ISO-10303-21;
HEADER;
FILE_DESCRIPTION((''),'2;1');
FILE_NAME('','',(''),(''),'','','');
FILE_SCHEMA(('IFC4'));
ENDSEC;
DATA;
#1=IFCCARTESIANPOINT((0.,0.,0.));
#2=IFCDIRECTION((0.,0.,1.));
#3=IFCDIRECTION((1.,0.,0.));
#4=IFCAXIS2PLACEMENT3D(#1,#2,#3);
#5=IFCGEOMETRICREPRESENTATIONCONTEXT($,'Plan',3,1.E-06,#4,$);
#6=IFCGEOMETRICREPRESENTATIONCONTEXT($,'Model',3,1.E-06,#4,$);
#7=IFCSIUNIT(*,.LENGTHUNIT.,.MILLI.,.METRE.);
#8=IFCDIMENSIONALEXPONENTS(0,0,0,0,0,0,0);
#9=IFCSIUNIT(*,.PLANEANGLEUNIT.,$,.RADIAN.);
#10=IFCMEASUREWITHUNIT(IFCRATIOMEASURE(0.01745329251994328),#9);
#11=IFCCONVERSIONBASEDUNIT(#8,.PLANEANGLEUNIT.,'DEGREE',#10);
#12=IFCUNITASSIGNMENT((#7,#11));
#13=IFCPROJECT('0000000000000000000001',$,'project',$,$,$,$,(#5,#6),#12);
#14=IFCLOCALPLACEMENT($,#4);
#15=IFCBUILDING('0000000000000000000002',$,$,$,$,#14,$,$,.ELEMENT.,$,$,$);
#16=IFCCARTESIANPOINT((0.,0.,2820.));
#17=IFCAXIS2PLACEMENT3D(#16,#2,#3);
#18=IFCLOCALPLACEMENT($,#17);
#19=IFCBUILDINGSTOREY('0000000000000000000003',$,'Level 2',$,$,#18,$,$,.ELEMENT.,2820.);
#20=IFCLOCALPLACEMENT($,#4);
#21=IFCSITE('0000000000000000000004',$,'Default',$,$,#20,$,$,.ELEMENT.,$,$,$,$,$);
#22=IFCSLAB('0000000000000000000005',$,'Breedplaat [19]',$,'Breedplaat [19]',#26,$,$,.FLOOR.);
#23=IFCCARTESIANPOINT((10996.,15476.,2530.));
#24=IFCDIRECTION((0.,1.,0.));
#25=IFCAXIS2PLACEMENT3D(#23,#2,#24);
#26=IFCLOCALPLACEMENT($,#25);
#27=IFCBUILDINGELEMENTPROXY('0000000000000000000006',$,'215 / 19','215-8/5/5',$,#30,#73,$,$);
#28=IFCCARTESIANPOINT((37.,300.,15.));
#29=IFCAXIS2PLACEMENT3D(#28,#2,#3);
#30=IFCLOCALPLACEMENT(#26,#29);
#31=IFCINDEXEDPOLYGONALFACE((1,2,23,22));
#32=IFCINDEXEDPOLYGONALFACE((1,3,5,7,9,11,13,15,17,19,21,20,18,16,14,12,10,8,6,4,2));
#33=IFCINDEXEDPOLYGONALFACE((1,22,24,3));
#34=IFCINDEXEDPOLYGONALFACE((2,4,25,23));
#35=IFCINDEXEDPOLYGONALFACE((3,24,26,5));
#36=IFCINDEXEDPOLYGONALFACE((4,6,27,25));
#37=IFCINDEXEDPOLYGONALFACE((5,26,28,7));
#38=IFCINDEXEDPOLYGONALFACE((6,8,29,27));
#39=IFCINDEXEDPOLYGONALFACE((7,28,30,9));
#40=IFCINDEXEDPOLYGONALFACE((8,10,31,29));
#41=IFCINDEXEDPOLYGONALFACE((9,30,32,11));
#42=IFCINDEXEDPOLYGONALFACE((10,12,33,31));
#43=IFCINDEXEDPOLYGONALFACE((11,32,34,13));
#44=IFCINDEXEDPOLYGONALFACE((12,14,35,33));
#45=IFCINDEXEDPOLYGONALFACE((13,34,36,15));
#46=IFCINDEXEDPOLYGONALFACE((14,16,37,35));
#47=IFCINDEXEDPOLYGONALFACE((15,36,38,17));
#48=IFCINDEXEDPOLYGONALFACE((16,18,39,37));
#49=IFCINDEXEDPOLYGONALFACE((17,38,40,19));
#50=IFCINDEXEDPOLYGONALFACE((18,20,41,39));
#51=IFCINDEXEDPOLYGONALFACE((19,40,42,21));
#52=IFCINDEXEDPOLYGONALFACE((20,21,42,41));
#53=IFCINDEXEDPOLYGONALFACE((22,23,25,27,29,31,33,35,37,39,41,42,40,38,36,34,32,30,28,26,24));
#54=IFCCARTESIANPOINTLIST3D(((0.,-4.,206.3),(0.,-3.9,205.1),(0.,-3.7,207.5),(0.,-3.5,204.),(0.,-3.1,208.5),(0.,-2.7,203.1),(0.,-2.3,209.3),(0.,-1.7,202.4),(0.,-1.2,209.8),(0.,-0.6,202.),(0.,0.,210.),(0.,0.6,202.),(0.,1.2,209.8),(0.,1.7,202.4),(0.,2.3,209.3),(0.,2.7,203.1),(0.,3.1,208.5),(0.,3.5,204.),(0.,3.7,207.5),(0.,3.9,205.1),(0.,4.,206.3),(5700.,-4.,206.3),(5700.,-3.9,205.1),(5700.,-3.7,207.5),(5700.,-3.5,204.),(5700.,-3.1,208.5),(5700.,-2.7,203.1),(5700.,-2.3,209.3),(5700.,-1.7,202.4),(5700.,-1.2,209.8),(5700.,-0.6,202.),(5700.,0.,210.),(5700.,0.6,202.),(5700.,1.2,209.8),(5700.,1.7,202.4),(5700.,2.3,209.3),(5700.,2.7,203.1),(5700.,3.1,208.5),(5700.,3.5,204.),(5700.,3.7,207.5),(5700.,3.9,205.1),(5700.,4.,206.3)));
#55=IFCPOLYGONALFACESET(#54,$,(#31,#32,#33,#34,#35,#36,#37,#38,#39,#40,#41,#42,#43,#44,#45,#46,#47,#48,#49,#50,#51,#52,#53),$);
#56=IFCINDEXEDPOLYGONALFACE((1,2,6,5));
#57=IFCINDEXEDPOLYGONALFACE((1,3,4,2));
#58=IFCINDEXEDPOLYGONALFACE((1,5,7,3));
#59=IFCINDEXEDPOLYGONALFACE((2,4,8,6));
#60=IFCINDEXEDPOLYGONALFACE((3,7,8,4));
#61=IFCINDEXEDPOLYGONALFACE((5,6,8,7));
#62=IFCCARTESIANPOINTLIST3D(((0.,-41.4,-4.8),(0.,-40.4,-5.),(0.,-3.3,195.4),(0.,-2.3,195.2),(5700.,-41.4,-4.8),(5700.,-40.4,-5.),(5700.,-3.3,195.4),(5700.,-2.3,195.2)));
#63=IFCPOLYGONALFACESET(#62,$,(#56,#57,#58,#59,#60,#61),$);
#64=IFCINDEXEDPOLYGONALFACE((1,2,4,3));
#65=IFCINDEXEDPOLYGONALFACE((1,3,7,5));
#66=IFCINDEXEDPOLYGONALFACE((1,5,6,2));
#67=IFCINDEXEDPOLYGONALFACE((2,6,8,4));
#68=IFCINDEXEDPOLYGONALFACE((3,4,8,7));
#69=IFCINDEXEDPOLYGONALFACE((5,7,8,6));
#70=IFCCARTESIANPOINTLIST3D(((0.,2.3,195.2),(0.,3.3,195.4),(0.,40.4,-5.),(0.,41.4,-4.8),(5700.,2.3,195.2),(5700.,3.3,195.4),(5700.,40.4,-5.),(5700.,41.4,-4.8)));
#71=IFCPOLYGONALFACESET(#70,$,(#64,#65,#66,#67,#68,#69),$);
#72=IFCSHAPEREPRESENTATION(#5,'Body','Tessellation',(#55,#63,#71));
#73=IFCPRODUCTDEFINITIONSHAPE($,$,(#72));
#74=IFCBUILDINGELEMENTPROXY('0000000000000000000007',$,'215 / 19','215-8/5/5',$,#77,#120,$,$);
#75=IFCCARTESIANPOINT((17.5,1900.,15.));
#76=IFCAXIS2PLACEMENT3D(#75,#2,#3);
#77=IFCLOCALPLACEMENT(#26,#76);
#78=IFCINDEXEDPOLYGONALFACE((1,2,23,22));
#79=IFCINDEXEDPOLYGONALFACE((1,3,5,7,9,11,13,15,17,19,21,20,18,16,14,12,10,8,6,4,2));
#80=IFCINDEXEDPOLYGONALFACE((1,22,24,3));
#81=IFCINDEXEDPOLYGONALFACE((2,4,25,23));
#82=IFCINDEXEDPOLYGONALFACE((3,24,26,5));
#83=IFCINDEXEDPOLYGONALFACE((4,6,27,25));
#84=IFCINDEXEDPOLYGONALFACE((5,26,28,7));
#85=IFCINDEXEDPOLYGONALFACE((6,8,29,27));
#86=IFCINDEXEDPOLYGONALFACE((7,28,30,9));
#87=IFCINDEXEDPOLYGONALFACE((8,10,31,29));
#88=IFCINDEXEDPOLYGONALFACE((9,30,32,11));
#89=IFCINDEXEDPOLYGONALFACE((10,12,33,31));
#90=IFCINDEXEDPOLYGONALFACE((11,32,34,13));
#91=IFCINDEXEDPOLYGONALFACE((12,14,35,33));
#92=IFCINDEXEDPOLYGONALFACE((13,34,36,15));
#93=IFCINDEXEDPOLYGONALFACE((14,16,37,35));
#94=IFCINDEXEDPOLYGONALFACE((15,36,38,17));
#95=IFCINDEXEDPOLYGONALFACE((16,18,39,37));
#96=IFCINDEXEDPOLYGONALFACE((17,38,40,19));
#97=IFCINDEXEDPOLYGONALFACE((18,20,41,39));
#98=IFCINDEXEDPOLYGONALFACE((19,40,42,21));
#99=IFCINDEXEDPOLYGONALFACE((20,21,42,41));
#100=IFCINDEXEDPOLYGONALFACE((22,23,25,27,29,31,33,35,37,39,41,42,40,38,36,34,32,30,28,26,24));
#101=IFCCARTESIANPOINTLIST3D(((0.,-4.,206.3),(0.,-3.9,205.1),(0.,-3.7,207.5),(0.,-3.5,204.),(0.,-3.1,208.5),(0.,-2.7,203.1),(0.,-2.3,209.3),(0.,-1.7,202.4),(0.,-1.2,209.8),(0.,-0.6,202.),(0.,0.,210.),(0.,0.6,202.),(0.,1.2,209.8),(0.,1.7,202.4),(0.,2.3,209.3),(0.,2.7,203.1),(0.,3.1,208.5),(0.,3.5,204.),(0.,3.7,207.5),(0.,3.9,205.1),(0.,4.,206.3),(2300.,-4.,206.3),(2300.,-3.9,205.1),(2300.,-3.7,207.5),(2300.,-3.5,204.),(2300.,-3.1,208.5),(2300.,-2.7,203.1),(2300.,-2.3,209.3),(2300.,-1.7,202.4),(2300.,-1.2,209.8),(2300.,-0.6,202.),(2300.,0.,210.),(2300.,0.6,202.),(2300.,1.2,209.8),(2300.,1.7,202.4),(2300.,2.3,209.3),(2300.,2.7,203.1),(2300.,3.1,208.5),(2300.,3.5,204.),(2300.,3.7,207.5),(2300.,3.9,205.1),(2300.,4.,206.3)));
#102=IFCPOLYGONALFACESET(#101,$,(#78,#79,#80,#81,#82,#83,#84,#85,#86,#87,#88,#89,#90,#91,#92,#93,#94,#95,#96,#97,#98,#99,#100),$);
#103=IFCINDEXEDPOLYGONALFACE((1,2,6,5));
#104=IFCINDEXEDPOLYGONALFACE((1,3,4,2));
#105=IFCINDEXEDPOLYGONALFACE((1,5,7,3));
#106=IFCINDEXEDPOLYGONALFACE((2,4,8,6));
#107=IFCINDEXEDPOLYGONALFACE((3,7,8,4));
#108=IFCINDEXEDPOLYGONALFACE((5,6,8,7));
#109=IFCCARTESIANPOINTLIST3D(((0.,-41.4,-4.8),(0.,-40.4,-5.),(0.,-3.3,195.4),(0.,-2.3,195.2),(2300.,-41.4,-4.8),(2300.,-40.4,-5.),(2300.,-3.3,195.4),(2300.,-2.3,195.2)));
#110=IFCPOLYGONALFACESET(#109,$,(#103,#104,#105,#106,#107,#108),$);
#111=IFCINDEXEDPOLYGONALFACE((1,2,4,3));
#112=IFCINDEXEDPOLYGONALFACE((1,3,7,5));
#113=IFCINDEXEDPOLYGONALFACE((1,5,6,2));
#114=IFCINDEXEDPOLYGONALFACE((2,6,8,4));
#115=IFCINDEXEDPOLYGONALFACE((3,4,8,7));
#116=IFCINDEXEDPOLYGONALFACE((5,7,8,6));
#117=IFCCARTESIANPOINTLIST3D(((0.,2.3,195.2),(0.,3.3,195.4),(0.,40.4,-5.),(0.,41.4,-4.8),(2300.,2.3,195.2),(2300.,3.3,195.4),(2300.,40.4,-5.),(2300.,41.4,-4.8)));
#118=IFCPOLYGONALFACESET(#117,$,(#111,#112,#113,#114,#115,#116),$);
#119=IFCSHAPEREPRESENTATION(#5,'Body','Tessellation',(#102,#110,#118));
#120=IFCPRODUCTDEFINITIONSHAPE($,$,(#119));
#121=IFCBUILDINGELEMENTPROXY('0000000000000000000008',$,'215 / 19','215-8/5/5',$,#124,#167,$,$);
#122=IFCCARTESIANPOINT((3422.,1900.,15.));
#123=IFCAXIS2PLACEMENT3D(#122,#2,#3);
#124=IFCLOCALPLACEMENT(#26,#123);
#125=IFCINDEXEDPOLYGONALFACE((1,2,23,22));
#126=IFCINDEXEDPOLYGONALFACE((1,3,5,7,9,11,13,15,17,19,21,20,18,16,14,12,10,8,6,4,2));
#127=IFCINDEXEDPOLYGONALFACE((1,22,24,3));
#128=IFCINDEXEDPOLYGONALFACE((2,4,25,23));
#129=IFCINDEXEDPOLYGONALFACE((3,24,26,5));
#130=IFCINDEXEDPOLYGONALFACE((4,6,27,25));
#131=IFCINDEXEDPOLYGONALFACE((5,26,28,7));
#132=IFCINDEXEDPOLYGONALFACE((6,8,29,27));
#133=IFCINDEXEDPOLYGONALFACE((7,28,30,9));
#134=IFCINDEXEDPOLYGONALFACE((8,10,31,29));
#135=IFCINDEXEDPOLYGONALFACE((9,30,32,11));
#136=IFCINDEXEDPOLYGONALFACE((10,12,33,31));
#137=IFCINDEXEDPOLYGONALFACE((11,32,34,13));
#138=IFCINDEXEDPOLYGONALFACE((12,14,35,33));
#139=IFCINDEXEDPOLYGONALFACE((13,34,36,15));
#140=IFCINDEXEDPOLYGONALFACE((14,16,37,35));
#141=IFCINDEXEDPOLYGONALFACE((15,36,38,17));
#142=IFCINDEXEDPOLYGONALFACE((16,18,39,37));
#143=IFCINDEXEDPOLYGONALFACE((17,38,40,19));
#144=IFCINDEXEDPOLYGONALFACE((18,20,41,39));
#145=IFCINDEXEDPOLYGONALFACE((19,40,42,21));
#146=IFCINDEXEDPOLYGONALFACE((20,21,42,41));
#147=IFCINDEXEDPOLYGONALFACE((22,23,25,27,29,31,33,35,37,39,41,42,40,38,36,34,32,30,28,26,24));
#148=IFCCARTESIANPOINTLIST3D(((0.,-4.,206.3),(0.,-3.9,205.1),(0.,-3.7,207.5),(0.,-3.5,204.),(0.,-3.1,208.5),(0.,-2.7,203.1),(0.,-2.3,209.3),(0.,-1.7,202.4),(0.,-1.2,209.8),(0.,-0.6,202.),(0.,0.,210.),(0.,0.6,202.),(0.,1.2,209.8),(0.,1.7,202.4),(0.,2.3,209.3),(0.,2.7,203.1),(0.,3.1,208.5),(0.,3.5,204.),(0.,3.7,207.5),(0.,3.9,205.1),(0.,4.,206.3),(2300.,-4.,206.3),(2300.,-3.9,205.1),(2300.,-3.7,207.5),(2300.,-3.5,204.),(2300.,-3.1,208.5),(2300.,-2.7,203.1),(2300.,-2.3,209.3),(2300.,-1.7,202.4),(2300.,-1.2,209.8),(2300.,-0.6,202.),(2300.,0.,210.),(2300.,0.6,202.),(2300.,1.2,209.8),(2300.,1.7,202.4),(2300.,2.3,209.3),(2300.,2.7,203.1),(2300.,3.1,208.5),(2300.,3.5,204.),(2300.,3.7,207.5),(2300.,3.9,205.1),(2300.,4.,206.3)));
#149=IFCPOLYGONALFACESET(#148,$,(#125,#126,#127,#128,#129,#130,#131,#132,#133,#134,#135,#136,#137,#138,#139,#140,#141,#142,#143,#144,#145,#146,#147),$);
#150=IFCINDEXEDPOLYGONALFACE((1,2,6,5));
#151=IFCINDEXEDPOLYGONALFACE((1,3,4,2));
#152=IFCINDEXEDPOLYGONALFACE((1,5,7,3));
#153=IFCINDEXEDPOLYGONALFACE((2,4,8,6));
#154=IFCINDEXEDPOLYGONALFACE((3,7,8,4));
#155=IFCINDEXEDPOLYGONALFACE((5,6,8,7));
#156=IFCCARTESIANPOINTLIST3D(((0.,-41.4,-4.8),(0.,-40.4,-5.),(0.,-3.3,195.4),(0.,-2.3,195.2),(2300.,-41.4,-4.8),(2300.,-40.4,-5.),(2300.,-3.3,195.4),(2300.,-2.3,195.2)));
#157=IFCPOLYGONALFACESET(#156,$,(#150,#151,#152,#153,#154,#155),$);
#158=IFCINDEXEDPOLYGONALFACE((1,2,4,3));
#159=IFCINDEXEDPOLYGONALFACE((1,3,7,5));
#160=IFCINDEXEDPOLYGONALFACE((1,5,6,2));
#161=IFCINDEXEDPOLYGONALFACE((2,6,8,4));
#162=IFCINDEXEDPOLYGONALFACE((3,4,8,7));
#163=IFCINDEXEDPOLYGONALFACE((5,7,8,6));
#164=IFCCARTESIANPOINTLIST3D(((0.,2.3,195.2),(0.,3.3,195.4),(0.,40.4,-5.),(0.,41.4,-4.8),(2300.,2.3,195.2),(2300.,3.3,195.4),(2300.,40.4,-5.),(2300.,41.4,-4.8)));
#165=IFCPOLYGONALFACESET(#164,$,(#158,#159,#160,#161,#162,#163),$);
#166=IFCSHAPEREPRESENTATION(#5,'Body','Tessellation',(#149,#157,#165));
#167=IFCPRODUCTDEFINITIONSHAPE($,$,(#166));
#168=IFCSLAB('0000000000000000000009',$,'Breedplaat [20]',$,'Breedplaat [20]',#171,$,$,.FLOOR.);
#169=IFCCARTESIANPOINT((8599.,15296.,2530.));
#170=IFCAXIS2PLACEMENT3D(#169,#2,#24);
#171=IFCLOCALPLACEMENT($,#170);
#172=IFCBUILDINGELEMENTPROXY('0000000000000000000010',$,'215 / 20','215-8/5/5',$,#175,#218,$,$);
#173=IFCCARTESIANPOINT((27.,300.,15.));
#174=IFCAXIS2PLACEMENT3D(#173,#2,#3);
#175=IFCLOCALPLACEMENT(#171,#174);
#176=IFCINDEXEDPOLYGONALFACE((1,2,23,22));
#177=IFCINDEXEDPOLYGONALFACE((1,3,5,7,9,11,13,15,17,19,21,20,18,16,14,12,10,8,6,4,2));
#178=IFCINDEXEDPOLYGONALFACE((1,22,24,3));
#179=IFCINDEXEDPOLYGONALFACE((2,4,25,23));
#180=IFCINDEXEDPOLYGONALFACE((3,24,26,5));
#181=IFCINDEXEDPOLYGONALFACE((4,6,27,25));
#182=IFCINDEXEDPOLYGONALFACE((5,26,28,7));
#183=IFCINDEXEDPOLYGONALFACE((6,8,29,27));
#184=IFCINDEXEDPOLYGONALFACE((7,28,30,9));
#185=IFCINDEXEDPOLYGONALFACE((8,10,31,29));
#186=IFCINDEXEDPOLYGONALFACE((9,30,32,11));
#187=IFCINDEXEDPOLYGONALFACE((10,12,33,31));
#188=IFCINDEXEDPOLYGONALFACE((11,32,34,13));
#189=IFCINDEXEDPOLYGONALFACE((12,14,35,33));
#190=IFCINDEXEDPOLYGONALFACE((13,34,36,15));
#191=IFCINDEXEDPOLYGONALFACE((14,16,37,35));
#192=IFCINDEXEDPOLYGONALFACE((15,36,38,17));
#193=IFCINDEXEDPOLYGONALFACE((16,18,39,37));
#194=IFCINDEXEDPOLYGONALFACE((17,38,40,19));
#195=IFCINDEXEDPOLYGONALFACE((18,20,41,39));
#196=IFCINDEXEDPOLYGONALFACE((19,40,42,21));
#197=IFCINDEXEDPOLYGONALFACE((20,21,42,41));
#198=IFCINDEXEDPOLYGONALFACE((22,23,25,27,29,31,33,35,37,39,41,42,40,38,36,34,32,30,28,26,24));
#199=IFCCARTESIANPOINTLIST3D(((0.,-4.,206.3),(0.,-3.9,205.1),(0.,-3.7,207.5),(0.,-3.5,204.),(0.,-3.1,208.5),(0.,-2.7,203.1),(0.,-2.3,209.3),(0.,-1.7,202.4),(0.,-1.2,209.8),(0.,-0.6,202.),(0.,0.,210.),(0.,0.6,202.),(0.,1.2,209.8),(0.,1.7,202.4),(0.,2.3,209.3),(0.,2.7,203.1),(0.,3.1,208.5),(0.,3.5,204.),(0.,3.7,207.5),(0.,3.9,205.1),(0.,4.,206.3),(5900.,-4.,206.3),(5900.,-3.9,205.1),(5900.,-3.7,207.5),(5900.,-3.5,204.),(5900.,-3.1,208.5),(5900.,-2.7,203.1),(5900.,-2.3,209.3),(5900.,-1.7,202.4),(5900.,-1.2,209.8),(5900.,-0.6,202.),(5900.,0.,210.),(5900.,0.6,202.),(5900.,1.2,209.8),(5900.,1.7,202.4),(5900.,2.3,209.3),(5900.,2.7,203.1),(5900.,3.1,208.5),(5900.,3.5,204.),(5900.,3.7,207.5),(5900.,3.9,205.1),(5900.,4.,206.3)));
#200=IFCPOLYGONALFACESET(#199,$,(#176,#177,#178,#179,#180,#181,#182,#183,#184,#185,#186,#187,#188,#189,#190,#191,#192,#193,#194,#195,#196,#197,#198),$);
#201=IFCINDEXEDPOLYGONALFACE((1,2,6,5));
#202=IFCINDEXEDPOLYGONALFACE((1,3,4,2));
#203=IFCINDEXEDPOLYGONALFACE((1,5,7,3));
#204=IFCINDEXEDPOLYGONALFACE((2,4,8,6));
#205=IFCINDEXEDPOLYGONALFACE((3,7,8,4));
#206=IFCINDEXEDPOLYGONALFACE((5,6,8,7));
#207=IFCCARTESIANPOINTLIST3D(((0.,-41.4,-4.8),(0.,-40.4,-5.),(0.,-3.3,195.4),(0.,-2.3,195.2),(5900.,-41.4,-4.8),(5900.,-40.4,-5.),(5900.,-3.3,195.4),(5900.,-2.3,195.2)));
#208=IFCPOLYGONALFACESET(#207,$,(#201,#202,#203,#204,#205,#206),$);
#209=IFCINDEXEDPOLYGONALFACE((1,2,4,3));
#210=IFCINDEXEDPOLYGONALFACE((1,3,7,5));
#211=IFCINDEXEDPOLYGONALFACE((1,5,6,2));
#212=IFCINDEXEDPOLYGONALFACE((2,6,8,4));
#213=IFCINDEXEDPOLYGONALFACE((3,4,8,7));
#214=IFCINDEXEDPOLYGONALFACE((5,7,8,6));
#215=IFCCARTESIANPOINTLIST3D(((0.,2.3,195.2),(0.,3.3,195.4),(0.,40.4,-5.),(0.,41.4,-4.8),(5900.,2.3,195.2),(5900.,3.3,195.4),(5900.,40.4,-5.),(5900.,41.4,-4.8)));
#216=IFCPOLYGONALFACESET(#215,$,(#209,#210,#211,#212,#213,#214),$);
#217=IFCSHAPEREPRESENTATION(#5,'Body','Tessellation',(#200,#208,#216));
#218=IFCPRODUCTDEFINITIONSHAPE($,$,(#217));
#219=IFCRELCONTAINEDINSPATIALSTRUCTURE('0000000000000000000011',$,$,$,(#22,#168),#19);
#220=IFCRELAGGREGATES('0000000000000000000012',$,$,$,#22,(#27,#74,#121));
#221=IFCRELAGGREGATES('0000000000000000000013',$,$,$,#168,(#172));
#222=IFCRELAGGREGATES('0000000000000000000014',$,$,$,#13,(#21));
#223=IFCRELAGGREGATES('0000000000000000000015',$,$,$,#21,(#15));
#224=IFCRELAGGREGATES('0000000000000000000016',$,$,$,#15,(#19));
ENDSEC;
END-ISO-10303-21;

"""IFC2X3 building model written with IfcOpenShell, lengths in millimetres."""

from ifc_helpers import new_model, entity, si_unit, converted_unit, frame, origin_with_axes, origin_2d_with_axis, place, context, project, spatial, rectangle, circle, extrude, element, aggregate, save


model = new_model("IFC2X3")

# Units and contexts
plan_context = context("Plan", 3, precision=1e-06, world=origin_with_axes())
model_context = context("Model", 3, precision=1e-06, world=origin_with_axes())
ifc_project = project(units=[si_unit("LENGTHUNIT", "METRE", prefix="MILLI"), converted_unit("PLANEANGLEUNIT", "DEGREE", entity("IfcRatioMeasure", 0.01745329251994328), si_unit("PLANEANGLEUNIT", "RADIAN"), dimensions=[0, 0, 0, 0, 0, 0, 0])], contexts=[plan_context, model_context])

# Site, building, storey
site_placement = place(None, origin_with_axes())
site = spatial("IfcSite", under=ifc_project, at=site_placement, Name="Default", CompositionType="ELEMENT")
building_placement = place(None, origin_with_axes())
building = spatial("IfcBuilding", under=site, at=building_placement, CompositionType="ELEMENT")
storey_placement = place(None, frame((0.0, 0.0, 2820.0), z_axis=(0.0, 0.0, 1.0), x_axis=(1.0, 0.0, 0.0)))
storey = spatial("IfcBuildingStorey", under=building, at=storey_placement, Name="Level 2", CompositionType="ELEMENT", Elevation=2820.0)

# Slab, building element proxies
slab_1_placement = place(None, frame((10996.0, 15476.0, 2530.0), z_axis=(0.0, 0.0, 1.0), x_axis=(0.0, 1.0, 0.0)))
slab_1 = element("IfcSlab", 1, at=slab_1_placement, inside=storey, Name="Breedplaat [19]", ObjectType="Breedplaat [19]", PredefinedType="FLOOR")
proxy_1_placement = place(slab_1_placement, frame((37.0, 300.0, 15.0), z_axis=(0.0, 0.0, 1.0), x_axis=(1.0, 0.0, 0.0)))
proxy_1 = element("IfcBuildingElementProxy", 2, at=proxy_1_placement, Name="215 / 19", Description="215-8/5/5", context=plan_context, shape_type="SweptSolid", body=[
    extrude(circle(Radius=4.0, at=origin_2d_with_axis()), frame((0.0, 0.0, 206.0), z_axis=(1.0, 0.0, 0.0), x_axis=(0.0, 0.0, 1.0)), (0.0, 0.0, 1.0), 5700.0),
    extrude(rectangle(XDim=203.8, YDim=1.0, at=origin_2d_with_axis()), frame((0.0, -21.9, 95.2), z_axis=(1.0, 0.0, 0.0), x_axis=(0.0, 0.187112, 0.982339)), (0.0, 0.0, 1.0), 5700.0),
    extrude(rectangle(XDim=203.8, YDim=1.0, at=origin_2d_with_axis()), frame((0.0, 21.9, 95.2), z_axis=(1.0, 0.0, 0.0), x_axis=(0.0, -0.187112, 0.982339)), (0.0, 0.0, 1.0), 5700.0),
])
proxy_2_placement = place(slab_1_placement, frame((17.5, 1900.0, 15.0), z_axis=(0.0, 0.0, 1.0), x_axis=(1.0, 0.0, 0.0)))
proxy_2 = element("IfcBuildingElementProxy", 3, at=proxy_2_placement, Name="215 / 19", Description="215-8/5/5", context=plan_context, shape_type="SweptSolid", body=[
    extrude(circle(Radius=4.0, at=origin_2d_with_axis()), frame((0.0, 0.0, 206.0), z_axis=(1.0, 0.0, 0.0), x_axis=(0.0, 0.0, 1.0)), (0.0, 0.0, 1.0), 2300.0),
    extrude(rectangle(XDim=203.8, YDim=1.0, at=origin_2d_with_axis()), frame((0.0, -21.9, 95.2), z_axis=(1.0, 0.0, 0.0), x_axis=(0.0, 0.187112, 0.982339)), (0.0, 0.0, 1.0), 2300.0),
    extrude(rectangle(XDim=203.8, YDim=1.0, at=origin_2d_with_axis()), frame((0.0, 21.9, 95.2), z_axis=(1.0, 0.0, 0.0), x_axis=(0.0, -0.187112, 0.982339)), (0.0, 0.0, 1.0), 2300.0),
])
proxy_3_placement = place(slab_1_placement, frame((3422.0, 1900.0, 15.0), z_axis=(0.0, 0.0, 1.0), x_axis=(1.0, 0.0, 0.0)))
proxy_3 = element("IfcBuildingElementProxy", 4, at=proxy_3_placement, Name="215 / 19", Description="215-8/5/5", context=plan_context, shape_type="SweptSolid", body=[
    extrude(circle(Radius=4.0, at=origin_2d_with_axis()), frame((0.0, 0.0, 206.0), z_axis=(1.0, 0.0, 0.0), x_axis=(0.0, 0.0, 1.0)), (0.0, 0.0, 1.0), 2300.0),
    extrude(rectangle(XDim=203.8, YDim=1.0, at=origin_2d_with_axis()), frame((0.0, -21.9, 95.2), z_axis=(1.0, 0.0, 0.0), x_axis=(0.0, 0.187112, 0.982339)), (0.0, 0.0, 1.0), 2300.0),
    extrude(rectangle(XDim=203.8, YDim=1.0, at=origin_2d_with_axis()), frame((0.0, 21.9, 95.2), z_axis=(1.0, 0.0, 0.0), x_axis=(0.0, -0.187112, 0.982339)), (0.0, 0.0, 1.0), 2300.0),
])
aggregate(slab_1, [proxy_1, proxy_2, proxy_3])

# Slab, building element proxy
slab_2_placement = place(None, frame((8599.0, 15296.0, 2530.0), z_axis=(0.0, 0.0, 1.0), x_axis=(0.0, 1.0, 0.0)))
slab_2 = element("IfcSlab", 5, at=slab_2_placement, inside=storey, Name="Breedplaat [20]", ObjectType="Breedplaat [20]", PredefinedType="FLOOR")
proxy_4_placement = place(slab_2_placement, frame((27.0, 300.0, 15.0), z_axis=(0.0, 0.0, 1.0), x_axis=(1.0, 0.0, 0.0)))
proxy_4 = element("IfcBuildingElementProxy", 6, at=proxy_4_placement, Name="215 / 20", Description="215-8/5/5", context=plan_context, shape_type="SweptSolid", body=[
    extrude(circle(Radius=4.0, at=origin_2d_with_axis()), frame((0.0, 0.0, 206.0), z_axis=(1.0, 0.0, 0.0), x_axis=(0.0, 0.0, 1.0)), (0.0, 0.0, 1.0), 5900.0),
    extrude(rectangle(XDim=203.8, YDim=1.0, at=origin_2d_with_axis()), frame((0.0, -21.9, 95.2), z_axis=(1.0, 0.0, 0.0), x_axis=(0.0, 0.187112, 0.982339)), (0.0, 0.0, 1.0), 5900.0),
    extrude(rectangle(XDim=203.8, YDim=1.0, at=origin_2d_with_axis()), frame((0.0, 21.9, 95.2), z_axis=(1.0, 0.0, 0.0), x_axis=(0.0, -0.187112, 0.982339)), (0.0, 0.0, 1.0), 5900.0),
])
aggregate(slab_2, [proxy_4])

save(model, "model.ifc")
